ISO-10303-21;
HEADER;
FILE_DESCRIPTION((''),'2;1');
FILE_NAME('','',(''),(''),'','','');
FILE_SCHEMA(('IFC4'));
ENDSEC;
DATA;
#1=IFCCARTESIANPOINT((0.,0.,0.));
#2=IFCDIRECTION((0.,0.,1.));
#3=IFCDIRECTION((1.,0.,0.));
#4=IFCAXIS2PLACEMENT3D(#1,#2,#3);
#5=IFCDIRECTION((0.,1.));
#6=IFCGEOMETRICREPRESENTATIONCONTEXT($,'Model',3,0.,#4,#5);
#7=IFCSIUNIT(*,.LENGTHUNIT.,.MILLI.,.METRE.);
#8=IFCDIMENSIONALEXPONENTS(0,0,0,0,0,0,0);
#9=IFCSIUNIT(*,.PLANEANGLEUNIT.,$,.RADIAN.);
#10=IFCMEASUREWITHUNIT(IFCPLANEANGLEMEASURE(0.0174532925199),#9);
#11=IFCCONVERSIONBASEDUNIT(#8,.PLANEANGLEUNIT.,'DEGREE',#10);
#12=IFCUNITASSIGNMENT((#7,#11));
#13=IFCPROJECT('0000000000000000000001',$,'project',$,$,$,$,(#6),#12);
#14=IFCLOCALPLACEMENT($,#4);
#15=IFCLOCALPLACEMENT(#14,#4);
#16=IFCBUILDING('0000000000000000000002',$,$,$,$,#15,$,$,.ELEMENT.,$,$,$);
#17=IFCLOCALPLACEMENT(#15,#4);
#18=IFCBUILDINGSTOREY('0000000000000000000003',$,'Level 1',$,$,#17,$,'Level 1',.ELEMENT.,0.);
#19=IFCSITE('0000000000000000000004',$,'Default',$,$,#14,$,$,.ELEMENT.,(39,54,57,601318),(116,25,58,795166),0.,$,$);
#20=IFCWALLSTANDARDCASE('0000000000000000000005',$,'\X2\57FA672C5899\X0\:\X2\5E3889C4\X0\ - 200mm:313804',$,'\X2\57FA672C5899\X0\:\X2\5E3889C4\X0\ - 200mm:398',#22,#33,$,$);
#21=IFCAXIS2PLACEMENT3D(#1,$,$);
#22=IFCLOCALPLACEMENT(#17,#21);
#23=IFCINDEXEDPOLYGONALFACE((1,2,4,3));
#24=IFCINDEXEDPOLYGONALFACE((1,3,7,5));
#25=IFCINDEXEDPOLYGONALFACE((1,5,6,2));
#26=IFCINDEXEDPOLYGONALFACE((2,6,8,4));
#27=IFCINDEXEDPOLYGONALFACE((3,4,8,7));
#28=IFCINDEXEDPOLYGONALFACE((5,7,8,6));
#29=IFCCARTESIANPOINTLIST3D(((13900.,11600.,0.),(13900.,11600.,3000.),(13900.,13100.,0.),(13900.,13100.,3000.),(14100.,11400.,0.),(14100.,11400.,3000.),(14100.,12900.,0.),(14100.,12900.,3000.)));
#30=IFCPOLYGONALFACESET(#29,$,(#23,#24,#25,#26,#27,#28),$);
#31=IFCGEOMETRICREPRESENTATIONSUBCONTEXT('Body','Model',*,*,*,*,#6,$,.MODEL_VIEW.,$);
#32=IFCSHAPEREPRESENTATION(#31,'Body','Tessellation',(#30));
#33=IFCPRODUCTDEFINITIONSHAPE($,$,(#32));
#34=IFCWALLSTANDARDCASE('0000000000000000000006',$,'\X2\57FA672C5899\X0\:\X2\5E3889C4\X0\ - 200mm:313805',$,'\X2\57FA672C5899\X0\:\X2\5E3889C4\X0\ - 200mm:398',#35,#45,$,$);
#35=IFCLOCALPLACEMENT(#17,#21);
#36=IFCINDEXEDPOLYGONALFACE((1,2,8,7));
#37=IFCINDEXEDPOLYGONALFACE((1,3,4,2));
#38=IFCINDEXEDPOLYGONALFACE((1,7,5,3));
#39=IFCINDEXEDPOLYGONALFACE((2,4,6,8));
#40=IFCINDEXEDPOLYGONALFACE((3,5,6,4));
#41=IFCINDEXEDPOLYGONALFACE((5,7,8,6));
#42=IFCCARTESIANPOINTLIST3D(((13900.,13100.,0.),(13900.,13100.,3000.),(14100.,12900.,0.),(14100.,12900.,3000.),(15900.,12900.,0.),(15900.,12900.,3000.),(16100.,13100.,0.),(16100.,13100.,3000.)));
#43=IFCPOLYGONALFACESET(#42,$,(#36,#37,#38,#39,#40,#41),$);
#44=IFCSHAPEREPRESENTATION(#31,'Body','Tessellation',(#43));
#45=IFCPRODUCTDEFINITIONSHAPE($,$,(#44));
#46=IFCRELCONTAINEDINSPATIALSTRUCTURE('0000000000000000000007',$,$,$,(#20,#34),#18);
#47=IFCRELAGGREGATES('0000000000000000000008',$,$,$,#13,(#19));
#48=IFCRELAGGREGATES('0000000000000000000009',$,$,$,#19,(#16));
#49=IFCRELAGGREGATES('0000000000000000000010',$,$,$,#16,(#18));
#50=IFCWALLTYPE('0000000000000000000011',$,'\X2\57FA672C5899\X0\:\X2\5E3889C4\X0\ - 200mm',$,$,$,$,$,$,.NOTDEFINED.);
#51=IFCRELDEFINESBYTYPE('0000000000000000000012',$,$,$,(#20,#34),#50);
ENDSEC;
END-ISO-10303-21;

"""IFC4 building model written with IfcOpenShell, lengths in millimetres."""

from ifc_helpers import new_model, entity, si_unit, converted_unit, direction, frame, origin_with_axes, place, context, subcontext, project, spatial, polyline, outline, extrude, type_object, element, save


model = new_model("IFC4")

# Units and contexts
model_context_1 = context("Model", 3, precision=0.0, world=origin_with_axes(), true_north=direction((0.0, 1.0)))
body_context_1 = subcontext(model_context_1, "Body", "Model", "MODEL_VIEW")
ifc_project = project(units=[si_unit("LENGTHUNIT", "METRE", prefix="MILLI"), converted_unit("PLANEANGLEUNIT", "DEGREE", entity("IfcPlaneAngleMeasure", 0.0174532925199), si_unit("PLANEANGLEUNIT", "RADIAN"), dimensions=[0, 0, 0, 0, 0, 0, 0])], contexts=[model_context_1])

# Site, building, storey
site_placement = place(None, origin_with_axes())
site = spatial("IfcSite", under=ifc_project, at=site_placement, Name="Default", CompositionType="ELEMENT", RefLatitude=(39, 54, 57, 601318), RefLongitude=(116, 25, 58, 795166), RefElevation=0.0)
building_placement = place(site_placement, origin_with_axes())
building = spatial("IfcBuilding", under=site, at=building_placement, CompositionType="ELEMENT")
storey_placement = place(building_placement, origin_with_axes())
storey = spatial("IfcBuildingStorey", under=building, at=storey_placement, Name="Level 1", LongName="Level 1", CompositionType="ELEMENT", Elevation=0.0)

# Shared definitions
wall_type_1 = type_object("IfcWallType", Name="基本墙:常规 - 200mm", PredefinedType="NOTDEFINED")

# Walls
wall_1_placement = place(storey_placement, frame((14000.0, 11500.0, 0.0), z_axis=(0.0, 0.0, 1.0), x_axis=(0.0, 1.0, 0.0)))
element("IfcWallStandardCase", 1, at=wall_1_placement, inside=storey, type_object=wall_type_1, Name="基本墙:常规 - 200mm:313804", ObjectType="基本墙:常规 - 200mm:398", context=body_context_1, shape_type="SweptSolid", body=[
    extrude(outline(polyline([(-100.0, -100.0), (1400.0, -100.0), (1600.0, 100.0), (100.0, 100.0), (-100.0, -100.0)])), origin_with_axes(), (0.0, 0.0, 1.0), 3000.0),
])
wall_2_placement = place(storey_placement, frame((14000.0, 13000.0, 0.0), z_axis=(0.0, 0.0, 1.0), x_axis=(1.0, 0.0, 0.0)))
element("IfcWallStandardCase", 2, at=wall_2_placement, inside=storey, type_object=wall_type_1, Name="基本墙:常规 - 200mm:313805", ObjectType="基本墙:常规 - 200mm:398", context=body_context_1, shape_type="SweptSolid", body=[
    extrude(outline(polyline([(100.0, -100.0), (1900.0, -100.0), (2100.0, 100.0), (-100.0, 100.0), (100.0, -100.0)])), origin_with_axes(), (0.0, 0.0, 1.0), 3000.0),
])

save(model, "model.ifc")
